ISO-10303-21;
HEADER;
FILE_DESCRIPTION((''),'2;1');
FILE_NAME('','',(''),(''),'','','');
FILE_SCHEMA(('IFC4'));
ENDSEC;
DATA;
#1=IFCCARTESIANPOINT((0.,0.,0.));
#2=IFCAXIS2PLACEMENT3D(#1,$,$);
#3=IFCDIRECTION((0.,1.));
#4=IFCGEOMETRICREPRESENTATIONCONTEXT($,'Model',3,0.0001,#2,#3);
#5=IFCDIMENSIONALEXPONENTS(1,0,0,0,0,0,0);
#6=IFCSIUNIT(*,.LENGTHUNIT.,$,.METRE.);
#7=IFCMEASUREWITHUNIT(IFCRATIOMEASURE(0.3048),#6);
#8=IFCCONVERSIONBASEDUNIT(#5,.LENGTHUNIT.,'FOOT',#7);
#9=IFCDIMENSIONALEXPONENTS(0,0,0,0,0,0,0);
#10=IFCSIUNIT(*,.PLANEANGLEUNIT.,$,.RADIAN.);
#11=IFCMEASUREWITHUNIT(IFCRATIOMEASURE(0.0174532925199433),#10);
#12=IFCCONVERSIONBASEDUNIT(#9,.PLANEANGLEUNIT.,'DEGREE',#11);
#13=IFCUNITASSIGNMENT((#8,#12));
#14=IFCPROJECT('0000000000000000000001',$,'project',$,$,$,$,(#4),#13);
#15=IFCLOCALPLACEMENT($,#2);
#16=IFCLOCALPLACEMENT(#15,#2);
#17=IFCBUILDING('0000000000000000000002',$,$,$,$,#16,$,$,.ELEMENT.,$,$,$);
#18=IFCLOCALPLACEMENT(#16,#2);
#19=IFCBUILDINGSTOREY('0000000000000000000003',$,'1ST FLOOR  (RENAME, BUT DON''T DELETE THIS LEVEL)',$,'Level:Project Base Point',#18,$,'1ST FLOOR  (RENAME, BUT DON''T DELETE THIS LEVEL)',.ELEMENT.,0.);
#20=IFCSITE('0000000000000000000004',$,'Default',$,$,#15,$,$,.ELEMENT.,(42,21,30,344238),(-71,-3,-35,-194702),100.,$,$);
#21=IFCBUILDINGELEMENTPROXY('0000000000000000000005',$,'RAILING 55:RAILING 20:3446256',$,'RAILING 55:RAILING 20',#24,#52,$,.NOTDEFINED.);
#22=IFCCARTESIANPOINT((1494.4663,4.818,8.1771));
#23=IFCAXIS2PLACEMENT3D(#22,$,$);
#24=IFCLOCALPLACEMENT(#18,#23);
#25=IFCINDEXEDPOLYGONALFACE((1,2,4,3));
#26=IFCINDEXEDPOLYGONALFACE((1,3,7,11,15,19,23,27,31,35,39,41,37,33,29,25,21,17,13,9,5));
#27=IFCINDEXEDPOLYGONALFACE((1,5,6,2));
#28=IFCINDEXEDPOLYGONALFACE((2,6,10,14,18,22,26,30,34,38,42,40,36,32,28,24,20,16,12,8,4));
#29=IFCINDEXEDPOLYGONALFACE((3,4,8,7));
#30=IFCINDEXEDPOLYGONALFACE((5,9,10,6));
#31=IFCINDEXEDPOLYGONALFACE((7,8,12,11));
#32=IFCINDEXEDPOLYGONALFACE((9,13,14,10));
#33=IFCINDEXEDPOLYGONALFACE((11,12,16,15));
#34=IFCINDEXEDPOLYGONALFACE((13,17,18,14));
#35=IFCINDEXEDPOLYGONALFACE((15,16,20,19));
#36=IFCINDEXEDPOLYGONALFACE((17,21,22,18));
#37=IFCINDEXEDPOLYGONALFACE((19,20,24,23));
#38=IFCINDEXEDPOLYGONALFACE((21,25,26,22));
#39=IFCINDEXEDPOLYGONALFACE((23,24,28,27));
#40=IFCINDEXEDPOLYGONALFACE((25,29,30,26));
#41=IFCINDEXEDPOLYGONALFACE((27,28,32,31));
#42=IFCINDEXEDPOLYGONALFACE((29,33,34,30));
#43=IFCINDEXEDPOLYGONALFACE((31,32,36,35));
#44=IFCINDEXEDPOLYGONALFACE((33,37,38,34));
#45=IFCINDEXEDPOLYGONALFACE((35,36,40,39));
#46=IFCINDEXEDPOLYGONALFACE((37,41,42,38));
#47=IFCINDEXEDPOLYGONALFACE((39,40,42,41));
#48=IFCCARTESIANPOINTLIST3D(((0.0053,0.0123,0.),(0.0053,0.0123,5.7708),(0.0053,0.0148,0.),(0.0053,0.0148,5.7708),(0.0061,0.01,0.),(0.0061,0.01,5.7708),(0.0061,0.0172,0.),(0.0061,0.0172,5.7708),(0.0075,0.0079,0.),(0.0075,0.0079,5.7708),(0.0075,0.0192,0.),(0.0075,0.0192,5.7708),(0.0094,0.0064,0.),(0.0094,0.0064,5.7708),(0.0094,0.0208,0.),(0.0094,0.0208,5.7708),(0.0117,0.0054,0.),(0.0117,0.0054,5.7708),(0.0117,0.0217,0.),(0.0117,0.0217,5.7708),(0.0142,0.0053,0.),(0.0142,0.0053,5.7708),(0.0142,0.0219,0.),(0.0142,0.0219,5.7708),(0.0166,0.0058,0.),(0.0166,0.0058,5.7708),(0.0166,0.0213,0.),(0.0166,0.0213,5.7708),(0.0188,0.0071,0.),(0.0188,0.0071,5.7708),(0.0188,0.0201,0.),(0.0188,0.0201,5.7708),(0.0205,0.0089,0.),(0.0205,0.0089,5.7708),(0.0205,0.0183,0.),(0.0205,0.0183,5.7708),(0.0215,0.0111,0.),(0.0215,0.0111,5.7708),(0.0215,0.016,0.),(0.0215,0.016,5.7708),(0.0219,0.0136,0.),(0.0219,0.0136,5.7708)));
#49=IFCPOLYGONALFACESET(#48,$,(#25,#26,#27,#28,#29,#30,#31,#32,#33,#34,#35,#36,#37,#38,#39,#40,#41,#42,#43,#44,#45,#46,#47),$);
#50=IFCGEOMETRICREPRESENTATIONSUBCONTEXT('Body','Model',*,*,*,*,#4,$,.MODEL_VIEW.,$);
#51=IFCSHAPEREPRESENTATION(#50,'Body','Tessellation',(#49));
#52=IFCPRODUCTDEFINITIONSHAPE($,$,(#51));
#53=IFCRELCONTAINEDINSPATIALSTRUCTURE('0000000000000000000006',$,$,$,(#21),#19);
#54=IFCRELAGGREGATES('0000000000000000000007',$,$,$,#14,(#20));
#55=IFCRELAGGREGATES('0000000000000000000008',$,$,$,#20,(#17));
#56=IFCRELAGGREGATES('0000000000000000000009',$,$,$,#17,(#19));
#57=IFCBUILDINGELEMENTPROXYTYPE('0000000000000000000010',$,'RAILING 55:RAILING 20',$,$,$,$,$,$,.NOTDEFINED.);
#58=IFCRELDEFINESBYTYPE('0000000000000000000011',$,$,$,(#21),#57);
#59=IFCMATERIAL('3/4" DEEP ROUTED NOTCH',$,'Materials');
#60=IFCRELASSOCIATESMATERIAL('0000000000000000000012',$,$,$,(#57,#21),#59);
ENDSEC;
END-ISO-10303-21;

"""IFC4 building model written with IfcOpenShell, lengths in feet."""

from ifc_helpers import new_model, entity, si_unit, converted_unit, direction, frame, origin, origin_2d_with_axis, place, context, subcontext, project, spatial, circle, extrude, source, transform, mapped, material, type_object, type_shapes, element, save


model = new_model("IFC4")

# Units and contexts
model_context = context("Model", 3, precision=0.0001, world=origin(), true_north=direction((0.0, 1.0)))
body_context = subcontext(model_context, "Body", "Model", "MODEL_VIEW")
ifc_project = project(units=[converted_unit("LENGTHUNIT", "FOOT", entity("IfcRatioMeasure", 0.3048), si_unit("LENGTHUNIT", "METRE"), dimensions=[1, 0, 0, 0, 0, 0, 0]), converted_unit("PLANEANGLEUNIT", "DEGREE", entity("IfcRatioMeasure", 0.0174532925199433), si_unit("PLANEANGLEUNIT", "RADIAN"), dimensions=[0, 0, 0, 0, 0, 0, 0])], contexts=[model_context])

# Site, building, storey
site_placement = place(None, origin())
site = spatial("IfcSite", under=ifc_project, at=site_placement, Name="Default", CompositionType="ELEMENT", RefLatitude=(42, 21, 30, 344238), RefLongitude=(-71, -3, -35, -194702), RefElevation=100.0)
building_placement = place(site_placement, origin())
building = spatial("IfcBuilding", under=site, at=building_placement, CompositionType="ELEMENT")
storey_placement = place(building_placement, origin())
storey = spatial("IfcBuildingStorey", under=building, at=storey_placement, Name="1ST FLOOR  (RENAME, BUT DON'T DELETE THIS LEVEL)", ObjectType="Level:Project Base Point", LongName="1ST FLOOR  (RENAME, BUT DON'T DELETE THIS LEVEL)", CompositionType="ELEMENT", Elevation=0.0)

# Building element proxy
ifc_material_1 = material(Name="3/4\" DEEP ROUTED NOTCH", Category="Materials")
building_element_proxy_type_1 = type_object("IfcBuildingElementProxyType", Name="RAILING 55:RAILING 20", PredefinedType="NOTDEFINED", material=ifc_material_1)
shared_shape_1 = source(origin(), body_context, "Body", "SweptSolid", [
    extrude(circle(Radius=0.0083, at=origin_2d_with_axis()), frame((0.0136, 0.0136, 0.0)), (0.0, 0.0, 1.0), 5.7708),
])
type_shapes(building_element_proxy_type_1, [shared_shape_1])
proxy_1_placement = place(storey_placement, frame((1494.4663, 4.818, 8.1771)))
element("IfcBuildingElementProxy", 1, at=proxy_1_placement, inside=storey, type_object=building_element_proxy_type_1, material=ifc_material_1, Name="RAILING 55:RAILING 20:3446256", ObjectType="RAILING 55:RAILING 20", PredefinedType="NOTDEFINED", context=body_context, shape_type="MappedRepresentation", body=[
    mapped(shared_shape_1, transform((0.0, 0.0, 0.0), scale=1.0)),
])

save(model, "model.ifc")
